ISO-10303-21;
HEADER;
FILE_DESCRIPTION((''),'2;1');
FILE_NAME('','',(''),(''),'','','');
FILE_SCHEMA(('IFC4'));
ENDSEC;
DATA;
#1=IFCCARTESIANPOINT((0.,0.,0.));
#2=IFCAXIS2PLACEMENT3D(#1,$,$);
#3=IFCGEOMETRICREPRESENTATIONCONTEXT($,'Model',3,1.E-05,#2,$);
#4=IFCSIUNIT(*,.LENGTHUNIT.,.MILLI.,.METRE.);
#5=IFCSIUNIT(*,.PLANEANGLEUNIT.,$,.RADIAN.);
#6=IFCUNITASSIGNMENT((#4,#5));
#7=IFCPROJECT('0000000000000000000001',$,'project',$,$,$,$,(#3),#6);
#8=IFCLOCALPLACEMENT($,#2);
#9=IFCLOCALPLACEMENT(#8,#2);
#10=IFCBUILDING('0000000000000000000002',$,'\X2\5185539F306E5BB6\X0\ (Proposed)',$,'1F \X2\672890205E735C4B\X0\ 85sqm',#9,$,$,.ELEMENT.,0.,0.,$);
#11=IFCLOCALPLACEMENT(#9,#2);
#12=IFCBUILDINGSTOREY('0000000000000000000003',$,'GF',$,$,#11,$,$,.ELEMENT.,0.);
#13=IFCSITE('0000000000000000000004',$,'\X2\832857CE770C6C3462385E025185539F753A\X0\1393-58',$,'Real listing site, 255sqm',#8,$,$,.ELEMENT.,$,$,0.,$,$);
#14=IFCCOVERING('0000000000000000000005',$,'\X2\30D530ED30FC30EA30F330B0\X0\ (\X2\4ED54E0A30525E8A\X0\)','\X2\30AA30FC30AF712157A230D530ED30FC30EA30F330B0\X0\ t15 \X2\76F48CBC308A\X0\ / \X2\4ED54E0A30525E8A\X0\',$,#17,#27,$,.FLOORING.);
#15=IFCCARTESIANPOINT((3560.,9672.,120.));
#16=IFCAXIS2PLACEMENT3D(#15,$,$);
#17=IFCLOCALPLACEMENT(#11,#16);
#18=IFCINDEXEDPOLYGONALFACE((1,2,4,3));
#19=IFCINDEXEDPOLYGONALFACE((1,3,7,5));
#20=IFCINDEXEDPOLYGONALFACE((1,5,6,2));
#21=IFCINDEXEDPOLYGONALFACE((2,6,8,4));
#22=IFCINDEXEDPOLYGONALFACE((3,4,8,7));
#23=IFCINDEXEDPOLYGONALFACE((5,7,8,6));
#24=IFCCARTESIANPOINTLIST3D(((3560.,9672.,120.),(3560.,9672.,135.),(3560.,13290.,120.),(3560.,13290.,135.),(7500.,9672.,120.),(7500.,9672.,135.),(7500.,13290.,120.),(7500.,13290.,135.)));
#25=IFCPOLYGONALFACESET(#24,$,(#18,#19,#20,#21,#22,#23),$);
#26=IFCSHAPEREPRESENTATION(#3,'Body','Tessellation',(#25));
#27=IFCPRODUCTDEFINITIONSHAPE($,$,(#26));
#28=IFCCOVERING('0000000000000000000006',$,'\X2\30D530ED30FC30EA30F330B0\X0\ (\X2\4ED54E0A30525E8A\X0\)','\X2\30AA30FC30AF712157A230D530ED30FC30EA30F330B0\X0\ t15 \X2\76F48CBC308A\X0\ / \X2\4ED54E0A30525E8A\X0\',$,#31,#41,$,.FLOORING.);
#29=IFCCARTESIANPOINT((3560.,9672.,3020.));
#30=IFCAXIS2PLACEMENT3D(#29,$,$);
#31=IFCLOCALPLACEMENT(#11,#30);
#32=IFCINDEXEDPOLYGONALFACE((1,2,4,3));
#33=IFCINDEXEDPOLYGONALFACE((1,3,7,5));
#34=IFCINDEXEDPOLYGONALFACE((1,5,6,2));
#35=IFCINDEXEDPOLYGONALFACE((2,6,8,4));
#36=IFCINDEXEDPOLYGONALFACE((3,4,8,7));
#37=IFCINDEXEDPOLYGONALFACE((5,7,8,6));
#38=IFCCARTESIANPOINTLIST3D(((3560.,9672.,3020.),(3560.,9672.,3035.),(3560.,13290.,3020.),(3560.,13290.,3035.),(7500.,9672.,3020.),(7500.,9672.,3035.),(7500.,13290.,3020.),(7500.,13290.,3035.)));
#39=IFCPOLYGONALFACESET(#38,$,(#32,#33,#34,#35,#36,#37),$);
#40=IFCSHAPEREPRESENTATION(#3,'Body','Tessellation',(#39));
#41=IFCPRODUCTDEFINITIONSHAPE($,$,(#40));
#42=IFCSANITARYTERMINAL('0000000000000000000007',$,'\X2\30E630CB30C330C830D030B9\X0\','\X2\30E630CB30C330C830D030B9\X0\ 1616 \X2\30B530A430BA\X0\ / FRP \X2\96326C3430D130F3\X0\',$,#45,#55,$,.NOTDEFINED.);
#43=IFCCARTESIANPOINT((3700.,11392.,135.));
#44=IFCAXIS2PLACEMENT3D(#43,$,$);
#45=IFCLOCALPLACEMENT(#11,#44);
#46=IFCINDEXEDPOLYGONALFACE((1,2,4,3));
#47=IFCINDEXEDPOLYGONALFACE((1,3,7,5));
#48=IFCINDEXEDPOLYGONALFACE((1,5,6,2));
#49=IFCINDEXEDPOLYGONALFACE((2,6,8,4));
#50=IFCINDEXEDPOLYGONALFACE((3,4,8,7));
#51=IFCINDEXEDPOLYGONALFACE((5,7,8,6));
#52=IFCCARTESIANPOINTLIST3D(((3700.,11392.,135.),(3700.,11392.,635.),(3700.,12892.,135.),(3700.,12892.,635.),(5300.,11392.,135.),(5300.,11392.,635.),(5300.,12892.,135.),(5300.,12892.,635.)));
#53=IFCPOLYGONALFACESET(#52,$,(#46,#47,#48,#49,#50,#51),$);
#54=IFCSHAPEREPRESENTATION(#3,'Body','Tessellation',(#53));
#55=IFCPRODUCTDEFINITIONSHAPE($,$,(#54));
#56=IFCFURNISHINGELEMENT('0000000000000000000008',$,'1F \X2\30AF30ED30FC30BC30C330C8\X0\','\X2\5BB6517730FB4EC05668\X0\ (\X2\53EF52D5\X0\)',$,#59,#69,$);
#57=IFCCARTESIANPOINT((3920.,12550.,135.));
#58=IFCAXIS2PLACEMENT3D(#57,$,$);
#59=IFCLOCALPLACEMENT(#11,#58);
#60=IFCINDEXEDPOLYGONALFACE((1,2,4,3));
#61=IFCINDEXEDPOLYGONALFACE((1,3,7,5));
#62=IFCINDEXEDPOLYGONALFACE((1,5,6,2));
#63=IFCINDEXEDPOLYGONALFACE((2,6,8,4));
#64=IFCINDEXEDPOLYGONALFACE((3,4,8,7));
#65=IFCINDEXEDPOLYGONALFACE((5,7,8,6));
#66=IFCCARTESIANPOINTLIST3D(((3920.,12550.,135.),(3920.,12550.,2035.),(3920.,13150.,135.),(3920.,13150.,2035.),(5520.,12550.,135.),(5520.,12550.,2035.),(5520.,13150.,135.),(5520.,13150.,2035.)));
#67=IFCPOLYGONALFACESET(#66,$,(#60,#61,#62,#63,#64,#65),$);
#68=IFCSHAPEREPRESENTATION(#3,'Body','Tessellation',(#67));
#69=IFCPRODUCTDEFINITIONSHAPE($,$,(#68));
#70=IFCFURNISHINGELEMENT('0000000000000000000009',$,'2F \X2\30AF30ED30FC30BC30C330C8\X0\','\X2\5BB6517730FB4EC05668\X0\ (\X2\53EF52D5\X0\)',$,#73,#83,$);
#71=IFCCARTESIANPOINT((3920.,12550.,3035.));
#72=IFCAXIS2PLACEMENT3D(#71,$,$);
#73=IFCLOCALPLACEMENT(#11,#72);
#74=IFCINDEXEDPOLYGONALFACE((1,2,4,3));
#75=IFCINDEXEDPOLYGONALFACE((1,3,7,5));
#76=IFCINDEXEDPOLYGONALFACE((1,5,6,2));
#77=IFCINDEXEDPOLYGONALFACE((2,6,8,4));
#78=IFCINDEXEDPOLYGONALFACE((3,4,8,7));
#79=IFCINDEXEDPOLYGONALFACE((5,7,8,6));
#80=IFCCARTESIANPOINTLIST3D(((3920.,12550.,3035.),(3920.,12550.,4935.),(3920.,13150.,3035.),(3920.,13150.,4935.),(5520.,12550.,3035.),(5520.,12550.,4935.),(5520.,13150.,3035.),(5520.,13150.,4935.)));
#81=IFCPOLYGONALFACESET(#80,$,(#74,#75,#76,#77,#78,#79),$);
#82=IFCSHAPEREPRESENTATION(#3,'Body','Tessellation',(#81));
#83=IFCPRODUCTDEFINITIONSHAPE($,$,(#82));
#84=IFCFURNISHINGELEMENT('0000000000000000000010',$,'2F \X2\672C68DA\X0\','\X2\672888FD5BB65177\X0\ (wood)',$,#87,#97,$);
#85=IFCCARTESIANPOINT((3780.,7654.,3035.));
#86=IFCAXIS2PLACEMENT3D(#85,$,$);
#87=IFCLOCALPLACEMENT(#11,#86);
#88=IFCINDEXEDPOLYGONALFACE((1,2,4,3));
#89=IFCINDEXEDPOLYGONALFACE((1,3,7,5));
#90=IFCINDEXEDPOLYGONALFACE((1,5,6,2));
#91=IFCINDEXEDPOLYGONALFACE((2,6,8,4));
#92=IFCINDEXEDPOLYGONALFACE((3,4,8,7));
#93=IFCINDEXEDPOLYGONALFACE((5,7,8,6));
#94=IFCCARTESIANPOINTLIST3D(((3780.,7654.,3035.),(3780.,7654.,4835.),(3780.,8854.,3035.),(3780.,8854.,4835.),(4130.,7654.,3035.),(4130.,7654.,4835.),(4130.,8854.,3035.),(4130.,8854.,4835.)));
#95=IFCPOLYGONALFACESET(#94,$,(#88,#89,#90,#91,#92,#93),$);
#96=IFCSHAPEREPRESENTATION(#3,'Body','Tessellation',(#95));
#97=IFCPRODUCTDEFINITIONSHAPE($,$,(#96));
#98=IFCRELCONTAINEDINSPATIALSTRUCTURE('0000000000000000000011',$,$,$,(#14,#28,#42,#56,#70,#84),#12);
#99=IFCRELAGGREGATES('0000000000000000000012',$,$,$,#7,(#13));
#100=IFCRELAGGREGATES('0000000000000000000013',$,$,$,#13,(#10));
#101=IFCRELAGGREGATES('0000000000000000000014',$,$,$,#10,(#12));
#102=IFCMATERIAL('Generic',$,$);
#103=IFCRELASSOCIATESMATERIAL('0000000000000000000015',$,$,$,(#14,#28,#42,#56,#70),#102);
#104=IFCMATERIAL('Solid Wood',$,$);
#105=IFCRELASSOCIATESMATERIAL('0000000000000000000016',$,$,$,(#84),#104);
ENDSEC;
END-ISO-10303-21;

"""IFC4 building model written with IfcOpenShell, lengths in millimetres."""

from ifc_helpers import new_model, si_unit, frame, frame_2d, origin, place, context, project, spatial, rectangle, extrude, material, element, save


model = new_model("IFC4")

# Units and contexts
model_context = context("Model", 3, precision=1e-05, world=origin())
ifc_project = project(units=[si_unit("LENGTHUNIT", "METRE", prefix="MILLI"), si_unit("PLANEANGLEUNIT", "RADIAN")], contexts=[model_context])

# Site, building, storey
site_placement = place(None, origin())
site = spatial("IfcSite", under=ifc_project, at=site_placement, Name="茨城県水戸市内原町1393-58", ObjectType="Real listing site, 255sqm", CompositionType="ELEMENT", RefElevation=0.0)
building_placement = place(site_placement, origin())
building = spatial("IfcBuilding", under=site, at=building_placement, Name="内原の家 (Proposed)", ObjectType="1F 木造平屋 85sqm", CompositionType="ELEMENT", ElevationOfRefHeight=0.0, ElevationOfTerrain=0.0)
storey_placement = place(building_placement, origin())
storey = spatial("IfcBuildingStorey", under=building, at=storey_placement, Name="GF", CompositionType="ELEMENT", Elevation=0.0)

# Shared definitions
ifc_material_1 = material(Name="Solid Wood")

# Coverings
ifc_material_2 = material(Name="Generic")
covering_1_placement = place(storey_placement, frame((3560.0, 9672.0, 120.0)))
element("IfcCovering", 1, at=covering_1_placement, inside=storey, material=ifc_material_2, Name="フローリング (仕上げ床)", Description="オーク無垢フローリング t15 直貼り / 仕上げ床", PredefinedType="FLOORING", context=model_context, shape_type="SweptSolid", body=[
    extrude(rectangle(XDim=3940.0, YDim=3618.0, at=frame_2d((1970.0, 1809.0))), frame((3560.0, 9672.0, 120.0)), (0.0, 0.0, 1.0), 15.0),
])
covering_2_placement = place(storey_placement, frame((3560.0, 9672.0, 3020.0)))
element("IfcCovering", 2, at=covering_2_placement, inside=storey, material=ifc_material_2, Name="フローリング (仕上げ床)", Description="オーク無垢フローリング t15 直貼り / 仕上げ床", PredefinedType="FLOORING", context=model_context, shape_type="SweptSolid", body=[
    extrude(rectangle(XDim=3940.0, YDim=3618.0, at=frame_2d((1970.0, 1809.0))), frame((3560.0, 9672.0, 3020.0)), (0.0, 0.0, 1.0), 15.0),
])

# Sanitary terminal
sanitary_terminal_placement = place(storey_placement, frame((3700.0, 11392.0, 135.0)))
element("IfcSanitaryTerminal", 3, at=sanitary_terminal_placement, inside=storey, material=ifc_material_2, Name="ユニットバス", Description="ユニットバス 1616 サイズ / FRP 防水パン", PredefinedType="NOTDEFINED", context=model_context, shape_type="SweptSolid", body=[
    extrude(rectangle(XDim=1600.0, YDim=1500.0, at=frame_2d((800.0, 750.0))), frame((3700.0, 11392.0, 135.0)), (0.0, 0.0, 1.0), 500.0),
])

# Furnishing elements
furnishing_1_placement = place(storey_placement, frame((3920.0, 12550.0, 135.0)))
element("IfcFurnishingElement", 4, at=furnishing_1_placement, inside=storey, material=ifc_material_2, Name="1F クローゼット", Description="家具・什器 (可動)", context=model_context, shape_type="SweptSolid", body=[
    extrude(rectangle(XDim=1600.0, YDim=600.0, at=frame_2d((800.0, 300.0))), frame((3920.0, 12550.0, 135.0)), (0.0, 0.0, 1.0), 1900.0),
])
furnishing_2_placement = place(storey_placement, frame((3920.0, 12550.0, 3035.0)))
element("IfcFurnishingElement", 5, at=furnishing_2_placement, inside=storey, material=ifc_material_2, Name="2F クローゼット", Description="家具・什器 (可動)", context=model_context, shape_type="SweptSolid", body=[
    extrude(rectangle(XDim=1600.0, YDim=600.0, at=frame_2d((800.0, 300.0))), frame((3920.0, 12550.0, 3035.0)), (0.0, 0.0, 1.0), 1900.0),
])
furnishing_3_placement = place(storey_placement, frame((3780.0, 7654.0, 3035.0)))
element("IfcFurnishingElement", 6, at=furnishing_3_placement, inside=storey, material=ifc_material_1, Name="2F 本棚", Description="木製家具 (wood)", context=model_context, shape_type="SweptSolid", body=[
    extrude(rectangle(XDim=350.0, YDim=1200.0, at=frame_2d((175.0, 600.0))), frame((3780.0, 7654.0, 3035.0)), (0.0, 0.0, 1.0), 1800.0),
])

save(model, "model.ifc")
